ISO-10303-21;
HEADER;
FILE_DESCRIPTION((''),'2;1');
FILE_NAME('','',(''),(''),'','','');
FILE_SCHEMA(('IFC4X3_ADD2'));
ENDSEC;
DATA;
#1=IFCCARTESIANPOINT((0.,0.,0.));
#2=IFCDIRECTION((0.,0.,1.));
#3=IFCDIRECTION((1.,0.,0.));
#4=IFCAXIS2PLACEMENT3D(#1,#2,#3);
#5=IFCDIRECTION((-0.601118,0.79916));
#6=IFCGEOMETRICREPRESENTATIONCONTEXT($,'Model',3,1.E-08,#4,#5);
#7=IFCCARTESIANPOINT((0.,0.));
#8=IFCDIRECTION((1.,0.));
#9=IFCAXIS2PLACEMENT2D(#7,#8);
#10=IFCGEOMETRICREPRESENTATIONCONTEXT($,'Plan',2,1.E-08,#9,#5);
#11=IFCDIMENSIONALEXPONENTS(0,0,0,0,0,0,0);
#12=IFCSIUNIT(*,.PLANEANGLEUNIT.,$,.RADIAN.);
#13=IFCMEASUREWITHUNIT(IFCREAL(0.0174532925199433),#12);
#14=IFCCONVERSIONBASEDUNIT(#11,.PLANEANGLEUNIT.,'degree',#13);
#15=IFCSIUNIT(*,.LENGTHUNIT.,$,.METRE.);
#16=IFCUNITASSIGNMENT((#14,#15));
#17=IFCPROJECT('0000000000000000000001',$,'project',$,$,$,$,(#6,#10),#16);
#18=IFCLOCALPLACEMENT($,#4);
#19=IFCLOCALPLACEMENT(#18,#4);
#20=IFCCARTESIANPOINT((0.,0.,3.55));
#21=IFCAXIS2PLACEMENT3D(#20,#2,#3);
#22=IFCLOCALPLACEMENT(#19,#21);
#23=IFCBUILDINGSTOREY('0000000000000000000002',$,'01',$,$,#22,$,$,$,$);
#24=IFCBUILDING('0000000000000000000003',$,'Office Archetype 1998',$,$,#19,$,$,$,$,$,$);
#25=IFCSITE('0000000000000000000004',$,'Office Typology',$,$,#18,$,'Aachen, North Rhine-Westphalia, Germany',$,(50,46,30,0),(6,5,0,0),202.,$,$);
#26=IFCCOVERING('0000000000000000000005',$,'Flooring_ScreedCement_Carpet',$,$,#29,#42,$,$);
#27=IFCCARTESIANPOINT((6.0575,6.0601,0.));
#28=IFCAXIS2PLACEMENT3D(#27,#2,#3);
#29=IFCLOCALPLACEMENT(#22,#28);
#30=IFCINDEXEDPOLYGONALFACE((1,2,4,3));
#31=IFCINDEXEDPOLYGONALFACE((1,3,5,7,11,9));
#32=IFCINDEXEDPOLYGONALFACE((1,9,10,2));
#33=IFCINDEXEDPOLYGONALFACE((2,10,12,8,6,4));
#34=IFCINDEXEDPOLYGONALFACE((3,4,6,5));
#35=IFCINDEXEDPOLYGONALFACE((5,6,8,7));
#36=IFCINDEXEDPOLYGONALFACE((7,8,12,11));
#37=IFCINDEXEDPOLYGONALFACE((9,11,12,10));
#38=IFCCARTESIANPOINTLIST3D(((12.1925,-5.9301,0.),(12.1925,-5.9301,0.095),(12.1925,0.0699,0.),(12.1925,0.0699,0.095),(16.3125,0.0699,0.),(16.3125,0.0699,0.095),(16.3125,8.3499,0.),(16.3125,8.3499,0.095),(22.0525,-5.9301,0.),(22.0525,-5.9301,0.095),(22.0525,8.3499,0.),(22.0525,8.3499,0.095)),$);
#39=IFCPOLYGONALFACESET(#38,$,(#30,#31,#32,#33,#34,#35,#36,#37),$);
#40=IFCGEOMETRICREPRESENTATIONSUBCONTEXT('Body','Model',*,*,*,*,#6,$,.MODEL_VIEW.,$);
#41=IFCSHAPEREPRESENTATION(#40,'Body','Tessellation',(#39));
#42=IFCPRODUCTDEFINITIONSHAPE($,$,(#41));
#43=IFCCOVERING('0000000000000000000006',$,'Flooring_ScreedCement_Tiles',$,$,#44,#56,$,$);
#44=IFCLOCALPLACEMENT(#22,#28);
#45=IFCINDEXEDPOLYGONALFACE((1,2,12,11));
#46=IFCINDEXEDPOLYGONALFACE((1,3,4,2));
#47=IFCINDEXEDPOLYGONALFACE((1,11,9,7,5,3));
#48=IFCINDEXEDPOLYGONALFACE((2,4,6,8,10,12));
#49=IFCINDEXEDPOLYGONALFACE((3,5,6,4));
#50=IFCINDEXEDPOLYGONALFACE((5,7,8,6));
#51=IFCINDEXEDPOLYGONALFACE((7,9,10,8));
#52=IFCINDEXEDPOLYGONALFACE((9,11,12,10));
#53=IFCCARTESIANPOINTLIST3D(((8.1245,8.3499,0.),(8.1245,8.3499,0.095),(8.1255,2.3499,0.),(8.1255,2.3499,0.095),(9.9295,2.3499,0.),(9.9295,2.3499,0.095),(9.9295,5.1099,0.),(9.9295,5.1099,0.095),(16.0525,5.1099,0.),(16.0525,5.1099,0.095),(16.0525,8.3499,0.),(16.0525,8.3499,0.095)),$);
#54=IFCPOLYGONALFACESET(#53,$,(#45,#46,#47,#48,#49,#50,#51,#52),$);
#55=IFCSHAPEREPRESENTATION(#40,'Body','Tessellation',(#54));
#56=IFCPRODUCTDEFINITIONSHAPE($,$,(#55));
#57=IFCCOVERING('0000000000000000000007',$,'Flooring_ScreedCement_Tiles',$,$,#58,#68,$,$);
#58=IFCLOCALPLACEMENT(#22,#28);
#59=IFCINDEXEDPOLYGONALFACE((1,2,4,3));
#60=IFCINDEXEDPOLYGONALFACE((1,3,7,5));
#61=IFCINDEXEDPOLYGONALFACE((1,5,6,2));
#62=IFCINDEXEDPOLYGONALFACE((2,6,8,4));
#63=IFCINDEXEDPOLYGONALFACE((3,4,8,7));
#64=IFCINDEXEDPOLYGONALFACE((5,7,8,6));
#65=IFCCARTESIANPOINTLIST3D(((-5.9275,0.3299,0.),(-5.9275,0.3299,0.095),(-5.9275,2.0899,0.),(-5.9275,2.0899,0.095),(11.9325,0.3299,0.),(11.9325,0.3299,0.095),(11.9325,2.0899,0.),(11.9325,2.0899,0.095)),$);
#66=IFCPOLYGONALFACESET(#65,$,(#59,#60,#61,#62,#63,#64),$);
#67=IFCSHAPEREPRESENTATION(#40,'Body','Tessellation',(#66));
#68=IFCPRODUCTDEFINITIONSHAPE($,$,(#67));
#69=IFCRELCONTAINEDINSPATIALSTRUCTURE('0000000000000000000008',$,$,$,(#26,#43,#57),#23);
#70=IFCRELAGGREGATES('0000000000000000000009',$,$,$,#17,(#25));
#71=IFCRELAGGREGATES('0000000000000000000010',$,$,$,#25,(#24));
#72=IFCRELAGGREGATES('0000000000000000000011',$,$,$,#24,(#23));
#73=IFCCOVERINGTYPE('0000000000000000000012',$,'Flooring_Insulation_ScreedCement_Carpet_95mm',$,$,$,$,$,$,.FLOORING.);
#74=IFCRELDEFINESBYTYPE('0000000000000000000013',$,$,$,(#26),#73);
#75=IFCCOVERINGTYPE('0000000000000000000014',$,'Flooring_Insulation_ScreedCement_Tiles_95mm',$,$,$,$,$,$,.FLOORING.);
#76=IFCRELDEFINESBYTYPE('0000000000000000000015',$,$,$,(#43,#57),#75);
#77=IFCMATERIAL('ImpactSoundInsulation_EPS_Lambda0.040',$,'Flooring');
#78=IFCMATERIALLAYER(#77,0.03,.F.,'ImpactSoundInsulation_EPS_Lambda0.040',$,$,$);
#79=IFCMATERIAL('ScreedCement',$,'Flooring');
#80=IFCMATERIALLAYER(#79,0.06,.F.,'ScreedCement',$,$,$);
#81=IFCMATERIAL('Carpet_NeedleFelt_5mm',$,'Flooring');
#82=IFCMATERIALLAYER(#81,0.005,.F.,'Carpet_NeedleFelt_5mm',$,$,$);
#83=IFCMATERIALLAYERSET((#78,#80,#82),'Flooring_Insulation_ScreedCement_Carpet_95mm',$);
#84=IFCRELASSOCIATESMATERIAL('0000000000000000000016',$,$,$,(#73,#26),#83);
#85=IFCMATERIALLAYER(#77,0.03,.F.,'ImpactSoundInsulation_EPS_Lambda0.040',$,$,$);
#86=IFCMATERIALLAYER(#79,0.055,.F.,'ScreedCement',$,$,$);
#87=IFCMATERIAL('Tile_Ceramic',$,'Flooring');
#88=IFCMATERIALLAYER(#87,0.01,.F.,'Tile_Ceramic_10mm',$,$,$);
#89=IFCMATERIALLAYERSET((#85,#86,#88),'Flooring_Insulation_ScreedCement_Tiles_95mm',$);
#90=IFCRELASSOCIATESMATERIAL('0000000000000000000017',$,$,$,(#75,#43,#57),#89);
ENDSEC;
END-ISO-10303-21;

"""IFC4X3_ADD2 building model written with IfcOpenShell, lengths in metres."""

from ifc_helpers import new_model, entity, si_unit, converted_unit, direction, frame, origin_with_axes, origin_2d_with_axis, place, context, subcontext, project, spatial, line, indexed_curve, outline, extrude, material, layer, layer_set, layer_usage, type_object, element, save


model = new_model("IFC4X3_ADD2")

# Units and contexts
model_context = context("Model", 3, precision=1e-08, world=origin_with_axes(), true_north=direction((-0.601118, 0.79916)))
plan_context = context("Plan", 2, precision=1e-08, world=origin_2d_with_axis(), true_north=direction((-0.601118, 0.79916)))
body_context = subcontext(model_context, "Body", "Model", "MODEL_VIEW")
ifc_project = project(units=[converted_unit("PLANEANGLEUNIT", "degree", entity("IfcReal", 0.0174532925199433), si_unit("PLANEANGLEUNIT", "RADIAN"), dimensions=[0, 0, 0, 0, 0, 0, 0]), si_unit("LENGTHUNIT", "METRE")], contexts=[model_context, plan_context])

# Site, building, storey
site_placement = place(None, origin_with_axes())
site = spatial("IfcSite", under=ifc_project, at=site_placement, Name="Office Typology", LongName="Aachen, North Rhine-Westphalia, Germany", RefLatitude=(50, 46, 30, 0), RefLongitude=(6, 5, 0, 0), RefElevation=202.0)
building_placement = place(site_placement, origin_with_axes())
building = spatial("IfcBuilding", under=site, at=building_placement, Name="Office Archetype 1998")
storey_placement = place(building_placement, frame((0.0, 0.0, 3.55), z_axis=(0.0, 0.0, 1.0), x_axis=(1.0, 0.0, 0.0)))
storey = spatial("IfcBuildingStorey", under=building, at=storey_placement, Name="01")

# Coverings
ifc_material_1 = material(Name="ImpactSoundInsulation_EPS_Lambda0.040", Category="Flooring")
ifc_layer_1 = layer(ifc_material_1, 0.03, ventilated=False, Name="ImpactSoundInsulation_EPS_Lambda0.040")
ifc_material_2 = material(Name="ScreedCement", Category="Flooring")
ifc_layer_2 = layer(ifc_material_2, 0.06, ventilated=False, Name="ScreedCement")
ifc_material_3 = material(Name="Carpet_NeedleFelt_5mm", Category="Flooring")
ifc_layer_3 = layer(ifc_material_3, 0.005, ventilated=False, Name="Carpet_NeedleFelt_5mm")
ifc_layer_set_1 = layer_set([ifc_layer_1, ifc_layer_2, ifc_layer_3], Name="Flooring_Insulation_ScreedCement_Carpet_95mm")
ifc_layer_usage_1 = layer_usage(ifc_layer_set_1, "AXIS3", "POSITIVE", 0.0)
covering_type_1 = type_object("IfcCoveringType", Name="Flooring_Insulation_ScreedCement_Carpet_95mm", PredefinedType="FLOORING", material=ifc_layer_set_1)
covering_1_placement = place(storey_placement, frame((6.0575, 6.0601, 0.0), z_axis=(0.0, 0.0, 1.0), x_axis=(1.0, 0.0, 0.0)))
element("IfcCovering", 1, at=covering_1_placement, inside=storey, type_object=covering_type_1, material=ifc_layer_usage_1, Name="Flooring_ScreedCement_Carpet", context=body_context, shape_type="SweptSolid", body=[
    extrude(outline(indexed_curve([(16.3125, 8.3499), (22.0525, 8.3499), (22.0525, -5.9301), (12.1925, -5.9301), (12.1925, 0.0699), (16.3125, 0.0699)], segments=[line(1, 2, 3, 4, 5, 6, 1)])), origin_with_axes(), (0.0, 0.0, 1.0), 0.095),
])
ifc_layer_4 = layer(ifc_material_1, 0.03, ventilated=False, Name="ImpactSoundInsulation_EPS_Lambda0.040")
ifc_layer_5 = layer(ifc_material_2, 0.055, ventilated=False, Name="ScreedCement")
ifc_material_4 = material(Name="Tile_Ceramic", Category="Flooring")
ifc_layer_6 = layer(ifc_material_4, 0.01, ventilated=False, Name="Tile_Ceramic_10mm")
ifc_layer_set_2 = layer_set([ifc_layer_4, ifc_layer_5, ifc_layer_6], Name="Flooring_Insulation_ScreedCement_Tiles_95mm")
ifc_layer_usage_2 = layer_usage(ifc_layer_set_2, "AXIS3", "POSITIVE", 0.0)
covering_type_2 = type_object("IfcCoveringType", Name="Flooring_Insulation_ScreedCement_Tiles_95mm", PredefinedType="FLOORING", material=ifc_layer_set_2)
covering_2_placement = place(storey_placement, frame((6.0575, 6.0601, 0.0), z_axis=(0.0, 0.0, 1.0), x_axis=(1.0, 0.0, 0.0)))
element("IfcCovering", 2, at=covering_2_placement, inside=storey, type_object=covering_type_2, material=ifc_layer_usage_2, Name="Flooring_ScreedCement_Tiles", context=body_context, shape_type="SweptSolid", body=[
    extrude(outline(indexed_curve([(9.9295, 2.3499), (8.1255, 2.3499), (8.1245, 8.3499), (16.0525, 8.3499), (16.0525, 5.1099), (9.9295, 5.1099)], segments=[line(1, 2, 3, 4, 5, 6, 1)])), None, (0.0, 0.0, 1.0), 0.095),
])
ifc_layer_usage_3 = layer_usage(ifc_layer_set_2, "AXIS3", "POSITIVE", 0.0)
covering_3_placement = place(storey_placement, frame((6.0575, 6.0601, 0.0), z_axis=(0.0, 0.0, 1.0), x_axis=(1.0, 0.0, 0.0)))
element("IfcCovering", 3, at=covering_3_placement, inside=storey, type_object=covering_type_2, material=ifc_layer_usage_3, Name="Flooring_ScreedCement_Tiles", context=body_context, shape_type="SweptSolid", body=[
    extrude(outline(indexed_curve([(-5.9275, 0.3299), (-5.9275, 2.0899), (11.9325, 2.0899), (11.9325, 0.3299)], segments=[line(1, 2, 3, 4, 1)])), None, (0.0, 0.0, 1.0), 0.095),
])

save(model, "model.ifc")
